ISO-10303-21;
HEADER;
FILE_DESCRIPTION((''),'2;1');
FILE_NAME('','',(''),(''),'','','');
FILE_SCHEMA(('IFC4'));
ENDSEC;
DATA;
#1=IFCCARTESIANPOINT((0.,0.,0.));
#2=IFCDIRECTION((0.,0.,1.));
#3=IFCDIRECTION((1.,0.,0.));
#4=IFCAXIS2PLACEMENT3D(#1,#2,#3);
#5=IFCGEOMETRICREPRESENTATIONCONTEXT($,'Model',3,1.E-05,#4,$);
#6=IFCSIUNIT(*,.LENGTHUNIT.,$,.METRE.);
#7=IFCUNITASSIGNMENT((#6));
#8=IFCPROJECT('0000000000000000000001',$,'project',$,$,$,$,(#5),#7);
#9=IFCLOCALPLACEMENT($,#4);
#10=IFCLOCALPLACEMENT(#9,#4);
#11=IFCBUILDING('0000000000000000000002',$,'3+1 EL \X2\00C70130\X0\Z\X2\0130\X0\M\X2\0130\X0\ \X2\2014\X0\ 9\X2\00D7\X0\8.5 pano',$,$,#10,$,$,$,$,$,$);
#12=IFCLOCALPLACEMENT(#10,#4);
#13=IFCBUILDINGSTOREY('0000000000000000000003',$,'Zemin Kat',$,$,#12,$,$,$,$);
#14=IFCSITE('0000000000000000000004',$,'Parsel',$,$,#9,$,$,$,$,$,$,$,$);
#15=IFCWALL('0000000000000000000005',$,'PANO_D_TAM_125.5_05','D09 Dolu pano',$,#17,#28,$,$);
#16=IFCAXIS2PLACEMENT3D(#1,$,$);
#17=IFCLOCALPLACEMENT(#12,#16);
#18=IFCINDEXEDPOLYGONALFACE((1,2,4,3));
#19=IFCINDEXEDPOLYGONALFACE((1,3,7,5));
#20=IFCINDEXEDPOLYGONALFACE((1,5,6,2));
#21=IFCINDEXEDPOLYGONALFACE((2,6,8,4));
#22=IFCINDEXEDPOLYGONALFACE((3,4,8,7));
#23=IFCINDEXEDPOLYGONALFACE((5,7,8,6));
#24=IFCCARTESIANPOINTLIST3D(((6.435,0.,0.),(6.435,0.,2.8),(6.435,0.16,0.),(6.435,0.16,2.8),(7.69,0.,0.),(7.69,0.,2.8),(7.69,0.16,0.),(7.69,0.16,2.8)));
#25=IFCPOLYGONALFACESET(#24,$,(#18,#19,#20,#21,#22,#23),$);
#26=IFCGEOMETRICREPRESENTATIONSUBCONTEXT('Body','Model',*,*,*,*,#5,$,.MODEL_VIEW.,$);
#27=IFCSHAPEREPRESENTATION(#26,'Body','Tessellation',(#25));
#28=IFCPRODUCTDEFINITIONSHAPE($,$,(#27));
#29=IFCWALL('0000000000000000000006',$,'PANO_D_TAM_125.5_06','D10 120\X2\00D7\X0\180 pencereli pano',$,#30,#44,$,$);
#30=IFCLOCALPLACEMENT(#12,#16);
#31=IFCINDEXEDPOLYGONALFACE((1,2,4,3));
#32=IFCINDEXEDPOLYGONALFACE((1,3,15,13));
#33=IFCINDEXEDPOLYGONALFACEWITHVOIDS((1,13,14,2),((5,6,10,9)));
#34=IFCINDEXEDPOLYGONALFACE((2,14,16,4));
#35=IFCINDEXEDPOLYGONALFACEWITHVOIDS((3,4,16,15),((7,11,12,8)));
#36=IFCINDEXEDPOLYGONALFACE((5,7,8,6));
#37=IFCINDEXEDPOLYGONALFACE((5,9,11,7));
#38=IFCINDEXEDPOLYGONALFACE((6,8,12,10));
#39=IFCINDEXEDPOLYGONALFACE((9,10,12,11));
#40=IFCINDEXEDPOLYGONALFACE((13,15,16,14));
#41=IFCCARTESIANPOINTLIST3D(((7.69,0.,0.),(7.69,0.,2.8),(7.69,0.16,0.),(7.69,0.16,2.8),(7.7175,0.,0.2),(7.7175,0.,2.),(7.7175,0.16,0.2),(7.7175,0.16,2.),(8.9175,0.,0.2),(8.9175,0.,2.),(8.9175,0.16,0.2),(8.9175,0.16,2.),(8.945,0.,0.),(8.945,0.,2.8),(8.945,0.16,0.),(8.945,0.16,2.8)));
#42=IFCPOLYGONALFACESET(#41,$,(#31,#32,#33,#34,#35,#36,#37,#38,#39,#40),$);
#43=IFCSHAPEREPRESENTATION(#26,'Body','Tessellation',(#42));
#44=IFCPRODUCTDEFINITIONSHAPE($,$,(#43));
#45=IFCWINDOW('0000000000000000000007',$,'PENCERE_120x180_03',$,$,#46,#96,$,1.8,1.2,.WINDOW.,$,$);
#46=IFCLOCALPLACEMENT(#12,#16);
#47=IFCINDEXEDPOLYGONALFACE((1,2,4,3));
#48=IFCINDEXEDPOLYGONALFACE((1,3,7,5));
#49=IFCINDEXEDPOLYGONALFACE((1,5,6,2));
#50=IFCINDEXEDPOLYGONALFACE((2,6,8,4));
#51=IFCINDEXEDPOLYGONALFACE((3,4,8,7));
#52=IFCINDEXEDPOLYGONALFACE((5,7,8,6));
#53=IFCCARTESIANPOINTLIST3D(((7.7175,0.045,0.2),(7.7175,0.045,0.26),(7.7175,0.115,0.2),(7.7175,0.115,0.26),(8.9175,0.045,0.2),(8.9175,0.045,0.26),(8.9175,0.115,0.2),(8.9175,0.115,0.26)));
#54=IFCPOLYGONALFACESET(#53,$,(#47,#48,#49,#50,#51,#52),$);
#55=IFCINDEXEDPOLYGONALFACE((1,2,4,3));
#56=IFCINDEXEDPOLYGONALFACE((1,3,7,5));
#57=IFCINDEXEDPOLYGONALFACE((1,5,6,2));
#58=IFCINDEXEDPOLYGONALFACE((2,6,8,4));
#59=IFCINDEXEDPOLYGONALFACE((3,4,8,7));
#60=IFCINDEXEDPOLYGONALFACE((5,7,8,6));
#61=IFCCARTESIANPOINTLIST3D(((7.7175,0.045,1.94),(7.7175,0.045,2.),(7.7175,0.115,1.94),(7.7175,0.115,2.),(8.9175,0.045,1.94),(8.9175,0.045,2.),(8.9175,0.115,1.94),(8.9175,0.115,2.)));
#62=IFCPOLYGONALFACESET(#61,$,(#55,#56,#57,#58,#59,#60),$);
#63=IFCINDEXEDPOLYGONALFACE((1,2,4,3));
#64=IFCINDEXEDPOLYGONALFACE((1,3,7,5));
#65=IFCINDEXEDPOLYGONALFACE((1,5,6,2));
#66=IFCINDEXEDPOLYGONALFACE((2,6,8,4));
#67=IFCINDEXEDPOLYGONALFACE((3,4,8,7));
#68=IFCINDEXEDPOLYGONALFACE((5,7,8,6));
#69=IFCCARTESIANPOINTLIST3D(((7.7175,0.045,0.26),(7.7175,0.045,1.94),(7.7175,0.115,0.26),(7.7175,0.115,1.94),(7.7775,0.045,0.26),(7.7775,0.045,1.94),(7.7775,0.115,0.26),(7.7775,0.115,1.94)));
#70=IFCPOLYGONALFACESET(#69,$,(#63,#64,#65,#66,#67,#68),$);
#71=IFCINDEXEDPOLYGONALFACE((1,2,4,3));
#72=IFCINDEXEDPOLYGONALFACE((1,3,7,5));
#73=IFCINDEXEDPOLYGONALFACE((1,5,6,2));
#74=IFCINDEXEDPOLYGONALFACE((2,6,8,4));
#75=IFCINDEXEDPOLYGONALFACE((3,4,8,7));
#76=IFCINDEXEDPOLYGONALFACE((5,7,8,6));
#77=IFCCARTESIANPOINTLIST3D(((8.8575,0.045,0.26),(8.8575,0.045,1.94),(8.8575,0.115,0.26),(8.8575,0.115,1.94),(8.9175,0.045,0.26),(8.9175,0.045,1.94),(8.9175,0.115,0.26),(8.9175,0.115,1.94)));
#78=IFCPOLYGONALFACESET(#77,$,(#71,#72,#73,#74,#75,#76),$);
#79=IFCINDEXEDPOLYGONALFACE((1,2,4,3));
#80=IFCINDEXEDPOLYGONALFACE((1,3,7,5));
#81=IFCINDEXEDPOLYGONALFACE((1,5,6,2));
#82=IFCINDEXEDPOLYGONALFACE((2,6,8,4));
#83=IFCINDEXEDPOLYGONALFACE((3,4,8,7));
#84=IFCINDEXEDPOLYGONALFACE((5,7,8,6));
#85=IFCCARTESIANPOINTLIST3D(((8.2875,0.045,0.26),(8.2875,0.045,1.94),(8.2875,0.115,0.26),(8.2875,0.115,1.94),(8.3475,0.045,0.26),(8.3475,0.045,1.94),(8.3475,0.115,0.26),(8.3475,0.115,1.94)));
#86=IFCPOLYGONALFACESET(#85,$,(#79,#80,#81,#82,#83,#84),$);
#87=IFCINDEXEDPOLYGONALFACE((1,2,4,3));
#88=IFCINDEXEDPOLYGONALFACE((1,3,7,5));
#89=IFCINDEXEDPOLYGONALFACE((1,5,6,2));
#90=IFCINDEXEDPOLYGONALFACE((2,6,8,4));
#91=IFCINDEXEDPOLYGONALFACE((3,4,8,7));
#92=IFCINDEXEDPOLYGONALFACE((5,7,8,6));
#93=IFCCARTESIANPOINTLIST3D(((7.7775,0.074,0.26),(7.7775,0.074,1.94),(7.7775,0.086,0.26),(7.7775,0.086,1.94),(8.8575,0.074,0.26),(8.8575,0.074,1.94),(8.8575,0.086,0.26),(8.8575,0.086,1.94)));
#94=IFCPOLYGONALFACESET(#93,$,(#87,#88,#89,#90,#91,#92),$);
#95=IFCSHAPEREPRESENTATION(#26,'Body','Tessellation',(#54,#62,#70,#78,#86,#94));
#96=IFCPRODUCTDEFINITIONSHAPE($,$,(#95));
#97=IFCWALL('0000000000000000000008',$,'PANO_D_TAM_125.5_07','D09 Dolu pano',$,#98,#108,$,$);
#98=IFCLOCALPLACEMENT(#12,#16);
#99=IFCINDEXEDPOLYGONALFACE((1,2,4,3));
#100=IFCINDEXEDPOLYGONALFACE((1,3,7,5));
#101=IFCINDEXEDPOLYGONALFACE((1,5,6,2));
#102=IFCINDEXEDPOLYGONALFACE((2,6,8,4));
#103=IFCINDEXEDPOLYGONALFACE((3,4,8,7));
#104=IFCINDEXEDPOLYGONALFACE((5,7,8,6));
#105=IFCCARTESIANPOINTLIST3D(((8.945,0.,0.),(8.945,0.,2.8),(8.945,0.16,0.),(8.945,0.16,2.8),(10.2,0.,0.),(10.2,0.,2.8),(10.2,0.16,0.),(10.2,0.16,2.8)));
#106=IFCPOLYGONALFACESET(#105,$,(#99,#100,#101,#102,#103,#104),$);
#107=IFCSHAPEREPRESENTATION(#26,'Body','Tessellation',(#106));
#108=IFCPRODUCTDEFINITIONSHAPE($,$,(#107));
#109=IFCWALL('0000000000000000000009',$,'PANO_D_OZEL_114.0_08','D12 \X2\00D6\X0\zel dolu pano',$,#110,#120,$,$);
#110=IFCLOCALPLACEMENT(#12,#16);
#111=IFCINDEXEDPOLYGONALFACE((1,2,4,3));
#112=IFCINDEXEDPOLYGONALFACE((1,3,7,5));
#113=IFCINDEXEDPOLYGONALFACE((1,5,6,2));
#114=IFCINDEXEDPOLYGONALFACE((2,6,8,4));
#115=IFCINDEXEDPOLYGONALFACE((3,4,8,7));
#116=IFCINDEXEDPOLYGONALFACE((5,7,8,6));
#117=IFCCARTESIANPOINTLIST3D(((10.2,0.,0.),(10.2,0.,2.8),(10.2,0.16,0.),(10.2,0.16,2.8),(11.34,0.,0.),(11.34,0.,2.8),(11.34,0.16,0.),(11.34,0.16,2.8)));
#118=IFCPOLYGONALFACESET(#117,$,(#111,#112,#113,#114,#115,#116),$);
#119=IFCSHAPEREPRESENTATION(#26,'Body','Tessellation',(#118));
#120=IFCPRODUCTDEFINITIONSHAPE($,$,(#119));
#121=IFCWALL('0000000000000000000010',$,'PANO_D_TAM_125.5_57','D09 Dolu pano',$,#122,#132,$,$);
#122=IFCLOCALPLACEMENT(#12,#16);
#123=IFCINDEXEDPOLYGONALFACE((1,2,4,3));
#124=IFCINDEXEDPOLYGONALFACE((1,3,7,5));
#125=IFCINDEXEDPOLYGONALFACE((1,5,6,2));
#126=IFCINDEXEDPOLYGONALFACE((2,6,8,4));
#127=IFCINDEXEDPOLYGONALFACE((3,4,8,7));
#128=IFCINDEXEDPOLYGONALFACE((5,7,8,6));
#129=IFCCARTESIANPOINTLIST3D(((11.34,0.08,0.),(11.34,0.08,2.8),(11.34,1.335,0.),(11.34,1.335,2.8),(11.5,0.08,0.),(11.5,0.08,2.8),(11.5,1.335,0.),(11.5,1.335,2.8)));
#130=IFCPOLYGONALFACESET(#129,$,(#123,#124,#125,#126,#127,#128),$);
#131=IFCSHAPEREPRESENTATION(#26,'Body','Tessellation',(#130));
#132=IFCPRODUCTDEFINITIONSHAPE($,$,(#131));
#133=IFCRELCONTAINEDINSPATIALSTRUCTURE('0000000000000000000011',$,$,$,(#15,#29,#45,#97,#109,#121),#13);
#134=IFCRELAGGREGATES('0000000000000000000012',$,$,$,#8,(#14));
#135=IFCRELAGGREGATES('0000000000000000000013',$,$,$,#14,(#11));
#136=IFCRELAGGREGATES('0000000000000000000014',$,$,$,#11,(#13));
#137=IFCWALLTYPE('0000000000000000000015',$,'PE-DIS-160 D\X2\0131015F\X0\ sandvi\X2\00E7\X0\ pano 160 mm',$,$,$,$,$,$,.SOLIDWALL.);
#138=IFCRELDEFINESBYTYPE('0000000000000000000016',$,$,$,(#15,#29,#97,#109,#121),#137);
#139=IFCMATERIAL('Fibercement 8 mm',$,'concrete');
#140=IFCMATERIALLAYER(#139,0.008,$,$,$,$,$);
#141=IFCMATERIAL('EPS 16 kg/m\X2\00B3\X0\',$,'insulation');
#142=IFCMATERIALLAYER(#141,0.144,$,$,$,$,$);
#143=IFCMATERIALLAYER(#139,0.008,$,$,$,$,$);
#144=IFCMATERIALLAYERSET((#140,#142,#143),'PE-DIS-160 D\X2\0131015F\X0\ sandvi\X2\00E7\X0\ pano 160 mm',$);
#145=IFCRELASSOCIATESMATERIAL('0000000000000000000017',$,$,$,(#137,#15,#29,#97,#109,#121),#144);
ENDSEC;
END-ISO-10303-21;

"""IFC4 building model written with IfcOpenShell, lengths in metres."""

from ifc_helpers import new_model, si_unit, frame, origin_with_axes, place, context, subcontext, project, spatial, line, indexed_curve, outline, extrude, material, layer, layer_set, layer_usage, type_object, element, fill, save


model = new_model("IFC4")

# Units and contexts
model_context = context("Model", 3, precision=1e-05, world=origin_with_axes())
body_context = subcontext(model_context, "Body", "Model", "MODEL_VIEW")
ifc_project = project(units=[si_unit("LENGTHUNIT", "METRE")], contexts=[model_context])

# Site, building, storey
site_placement = place(None, origin_with_axes())
site = spatial("IfcSite", under=ifc_project, at=site_placement, Name="Parsel")
building_placement = place(site_placement, origin_with_axes())
building = spatial("IfcBuilding", under=site, at=building_placement, Name="3+1 EL ÇİZİMİ — 9×8.5 pano")
storey_placement = place(building_placement, origin_with_axes())
storey = spatial("IfcBuildingStorey", under=building, at=storey_placement, Name="Zemin Kat")

# Wall
ifc_material_1 = material(Name="Fibercement 8 mm", Category="concrete")
ifc_layer_1 = layer(ifc_material_1, 0.008)
ifc_material_2 = material(Name="EPS 16 kg/m³", Category="insulation")
ifc_layer_2 = layer(ifc_material_2, 0.144)
ifc_layer_3 = layer(ifc_material_1, 0.008)
ifc_layer_set_1 = layer_set([ifc_layer_1, ifc_layer_2, ifc_layer_3], Name="PE-DIS-160 Dış sandviç pano 160 mm")
ifc_layer_usage_1 = layer_usage(ifc_layer_set_1, "AXIS2", "POSITIVE", 0.0)
wall_type_1 = type_object("IfcWallType", Name="PE-DIS-160 Dış sandviç pano 160 mm", PredefinedType="SOLIDWALL", material=ifc_layer_set_1)
wall_1_placement = place(storey_placement, frame((6.435, 0.0, 0.0), z_axis=(0.0, 0.0, 1.0), x_axis=(1.0, 0.0, 0.0)))
element("IfcWall", 1, at=wall_1_placement, inside=storey, type_object=wall_type_1, material=ifc_layer_usage_1, Name="PANO_D_TAM_125.5_05", Description="D09 Dolu pano", context=body_context, shape_type="SweptSolid", body=[
    extrude(outline(indexed_curve([(0.0, 0.0), (1.255, 0.0), (1.255, 0.16), (0.0, 0.16)], segments=[line(1, 2, 3, 4, 1)])), origin_with_axes(), (0.0, 0.0, 1.0), 2.8),
])

# Wall, opening, window
ifc_layer_usage_2 = layer_usage(ifc_layer_set_1, "AXIS2", "POSITIVE", 0.0)
wall_2_placement = place(storey_placement, frame((7.69, 0.0, 0.0), z_axis=(0.0, 0.0, 1.0), x_axis=(1.0, 0.0, 0.0)))
wall_2 = element("IfcWall", 2, at=wall_2_placement, inside=storey, type_object=wall_type_1, material=ifc_layer_usage_2, Name="PANO_D_TAM_125.5_06", Description="D10 120×180 pencereli pano", context=body_context, shape_type="SweptSolid", body=[
    extrude(outline(indexed_curve([(0.0, 0.0), (1.255, 0.0), (1.255, 0.16), (0.0, 0.16)], segments=[line(1, 2, 3, 4, 1)])), origin_with_axes(), (0.0, 0.0, 1.0), 2.8),
])
opening_1_placement = place(wall_2_placement, origin_with_axes())
opening_1 = element("IfcOpeningElement", 3, at=opening_1_placement, cuts=wall_2, PredefinedType="OPENING", context=body_context, shape_type="SweptSolid", body=[
    extrude(outline(indexed_curve([(0.0, 0.0), (1.2, 0.0), (1.2, 0.2), (0.0, 0.2)], segments=[line(1, 2, 3, 4, 1)])), frame((0.0275, -0.02, 0.2), z_axis=(0.0, 0.0, 1.0), x_axis=(1.0, 0.0, 0.0)), (0.0, 0.0, 1.0), 1.8),
])
window_1_placement = place(storey_placement, frame((7.69, 0.0, 0.0), z_axis=(0.0, 0.0, 1.0), x_axis=(1.0, 0.0, 0.0)))
window_1 = element("IfcWindow", 4, at=window_1_placement, inside=storey, Name="PENCERE_120x180_03", OverallHeight=1.8, OverallWidth=1.2, PredefinedType="WINDOW", context=body_context, shape_type="SweptSolid", body=[
    extrude(outline(indexed_curve([(0.0, 0.0), (1.2, 0.0), (1.2, 0.07), (0.0, 0.07)], segments=[line(1, 2, 3, 4, 1)])), frame((0.0275, 0.045, 0.2), z_axis=(0.0, 0.0, 1.0), x_axis=(1.0, 0.0, 0.0)), (0.0, 0.0, 1.0), 0.06),
    extrude(outline(indexed_curve([(0.0, 0.0), (1.2, 0.0), (1.2, 0.07), (0.0, 0.07)], segments=[line(1, 2, 3, 4, 1)])), frame((0.0275, 0.045, 1.94), z_axis=(0.0, 0.0, 1.0), x_axis=(1.0, 0.0, 0.0)), (0.0, 0.0, 1.0), 0.06),
    extrude(outline(indexed_curve([(0.0, 0.0), (0.06, 0.0), (0.06, 0.07), (0.0, 0.07)], segments=[line(1, 2, 3, 4, 1)])), frame((0.0275, 0.045, 0.26), z_axis=(0.0, 0.0, 1.0), x_axis=(1.0, 0.0, 0.0)), (0.0, 0.0, 1.0), 1.68),
    extrude(outline(indexed_curve([(0.0, 0.0), (0.06, 0.0), (0.06, 0.07), (0.0, 0.07)], segments=[line(1, 2, 3, 4, 1)])), frame((1.1675, 0.045, 0.26), z_axis=(0.0, 0.0, 1.0), x_axis=(1.0, 0.0, 0.0)), (0.0, 0.0, 1.0), 1.68),
    extrude(outline(indexed_curve([(0.0, 0.0), (0.06, 0.0), (0.06, 0.07), (0.0, 0.07)], segments=[line(1, 2, 3, 4, 1)])), frame((0.5975, 0.045, 0.26), z_axis=(0.0, 0.0, 1.0), x_axis=(1.0, 0.0, 0.0)), (0.0, 0.0, 1.0), 1.68),
    extrude(outline(indexed_curve([(0.0, 0.0), (1.08, 0.0), (1.08, 0.012), (0.0, 0.012)], segments=[line(1, 2, 3, 4, 1)])), frame((0.0875, 0.074, 0.26), z_axis=(0.0, 0.0, 1.0), x_axis=(1.0, 0.0, 0.0)), (0.0, 0.0, 1.0), 1.68),
])
fill(opening_1, window_1)

# Walls
ifc_layer_usage_3 = layer_usage(ifc_layer_set_1, "AXIS2", "POSITIVE", 0.0)
wall_3_placement = place(storey_placement, frame((8.945, 0.0, 0.0), z_axis=(0.0, 0.0, 1.0), x_axis=(1.0, 0.0, 0.0)))
element("IfcWall", 5, at=wall_3_placement, inside=storey, type_object=wall_type_1, material=ifc_layer_usage_3, Name="PANO_D_TAM_125.5_07", Description="D09 Dolu pano", context=body_context, shape_type="SweptSolid", body=[
    extrude(outline(indexed_curve([(0.0, 0.0), (1.255, 0.0), (1.255, 0.16), (0.0, 0.16)], segments=[line(1, 2, 3, 4, 1)])), origin_with_axes(), (0.0, 0.0, 1.0), 2.8),
])
ifc_layer_usage_4 = layer_usage(ifc_layer_set_1, "AXIS2", "POSITIVE", 0.0)
wall_4_placement = place(storey_placement, frame((10.2, 0.0, 0.0), z_axis=(0.0, 0.0, 1.0), x_axis=(1.0, 0.0, 0.0)))
element("IfcWall", 6, at=wall_4_placement, inside=storey, type_object=wall_type_1, material=ifc_layer_usage_4, Name="PANO_D_OZEL_114.0_08", Description="D12 Özel dolu pano", context=body_context, shape_type="SweptSolid", body=[
    extrude(outline(indexed_curve([(0.0, 0.0), (1.14, 0.0), (1.14, 0.16), (0.0, 0.16)], segments=[line(1, 2, 3, 4, 1)])), origin_with_axes(), (0.0, 0.0, 1.0), 2.8),
])
ifc_layer_usage_5 = layer_usage(ifc_layer_set_1, "AXIS2", "POSITIVE", 0.0)
wall_5_placement = place(storey_placement, frame((11.5, 0.08, 0.0), z_axis=(0.0, 0.0, 1.0), x_axis=(0.0, 1.0, 0.0)))
element("IfcWall", 7, at=wall_5_placement, inside=storey, type_object=wall_type_1, material=ifc_layer_usage_5, Name="PANO_D_TAM_125.5_57", Description="D09 Dolu pano", context=body_context, shape_type="SweptSolid", body=[
    extrude(outline(indexed_curve([(0.0, 0.0), (1.255, 0.0), (1.255, 0.16), (0.0, 0.16)], segments=[line(1, 2, 3, 4, 1)])), origin_with_axes(), (0.0, 0.0, 1.0), 2.8),
])

save(model, "model.ifc")
